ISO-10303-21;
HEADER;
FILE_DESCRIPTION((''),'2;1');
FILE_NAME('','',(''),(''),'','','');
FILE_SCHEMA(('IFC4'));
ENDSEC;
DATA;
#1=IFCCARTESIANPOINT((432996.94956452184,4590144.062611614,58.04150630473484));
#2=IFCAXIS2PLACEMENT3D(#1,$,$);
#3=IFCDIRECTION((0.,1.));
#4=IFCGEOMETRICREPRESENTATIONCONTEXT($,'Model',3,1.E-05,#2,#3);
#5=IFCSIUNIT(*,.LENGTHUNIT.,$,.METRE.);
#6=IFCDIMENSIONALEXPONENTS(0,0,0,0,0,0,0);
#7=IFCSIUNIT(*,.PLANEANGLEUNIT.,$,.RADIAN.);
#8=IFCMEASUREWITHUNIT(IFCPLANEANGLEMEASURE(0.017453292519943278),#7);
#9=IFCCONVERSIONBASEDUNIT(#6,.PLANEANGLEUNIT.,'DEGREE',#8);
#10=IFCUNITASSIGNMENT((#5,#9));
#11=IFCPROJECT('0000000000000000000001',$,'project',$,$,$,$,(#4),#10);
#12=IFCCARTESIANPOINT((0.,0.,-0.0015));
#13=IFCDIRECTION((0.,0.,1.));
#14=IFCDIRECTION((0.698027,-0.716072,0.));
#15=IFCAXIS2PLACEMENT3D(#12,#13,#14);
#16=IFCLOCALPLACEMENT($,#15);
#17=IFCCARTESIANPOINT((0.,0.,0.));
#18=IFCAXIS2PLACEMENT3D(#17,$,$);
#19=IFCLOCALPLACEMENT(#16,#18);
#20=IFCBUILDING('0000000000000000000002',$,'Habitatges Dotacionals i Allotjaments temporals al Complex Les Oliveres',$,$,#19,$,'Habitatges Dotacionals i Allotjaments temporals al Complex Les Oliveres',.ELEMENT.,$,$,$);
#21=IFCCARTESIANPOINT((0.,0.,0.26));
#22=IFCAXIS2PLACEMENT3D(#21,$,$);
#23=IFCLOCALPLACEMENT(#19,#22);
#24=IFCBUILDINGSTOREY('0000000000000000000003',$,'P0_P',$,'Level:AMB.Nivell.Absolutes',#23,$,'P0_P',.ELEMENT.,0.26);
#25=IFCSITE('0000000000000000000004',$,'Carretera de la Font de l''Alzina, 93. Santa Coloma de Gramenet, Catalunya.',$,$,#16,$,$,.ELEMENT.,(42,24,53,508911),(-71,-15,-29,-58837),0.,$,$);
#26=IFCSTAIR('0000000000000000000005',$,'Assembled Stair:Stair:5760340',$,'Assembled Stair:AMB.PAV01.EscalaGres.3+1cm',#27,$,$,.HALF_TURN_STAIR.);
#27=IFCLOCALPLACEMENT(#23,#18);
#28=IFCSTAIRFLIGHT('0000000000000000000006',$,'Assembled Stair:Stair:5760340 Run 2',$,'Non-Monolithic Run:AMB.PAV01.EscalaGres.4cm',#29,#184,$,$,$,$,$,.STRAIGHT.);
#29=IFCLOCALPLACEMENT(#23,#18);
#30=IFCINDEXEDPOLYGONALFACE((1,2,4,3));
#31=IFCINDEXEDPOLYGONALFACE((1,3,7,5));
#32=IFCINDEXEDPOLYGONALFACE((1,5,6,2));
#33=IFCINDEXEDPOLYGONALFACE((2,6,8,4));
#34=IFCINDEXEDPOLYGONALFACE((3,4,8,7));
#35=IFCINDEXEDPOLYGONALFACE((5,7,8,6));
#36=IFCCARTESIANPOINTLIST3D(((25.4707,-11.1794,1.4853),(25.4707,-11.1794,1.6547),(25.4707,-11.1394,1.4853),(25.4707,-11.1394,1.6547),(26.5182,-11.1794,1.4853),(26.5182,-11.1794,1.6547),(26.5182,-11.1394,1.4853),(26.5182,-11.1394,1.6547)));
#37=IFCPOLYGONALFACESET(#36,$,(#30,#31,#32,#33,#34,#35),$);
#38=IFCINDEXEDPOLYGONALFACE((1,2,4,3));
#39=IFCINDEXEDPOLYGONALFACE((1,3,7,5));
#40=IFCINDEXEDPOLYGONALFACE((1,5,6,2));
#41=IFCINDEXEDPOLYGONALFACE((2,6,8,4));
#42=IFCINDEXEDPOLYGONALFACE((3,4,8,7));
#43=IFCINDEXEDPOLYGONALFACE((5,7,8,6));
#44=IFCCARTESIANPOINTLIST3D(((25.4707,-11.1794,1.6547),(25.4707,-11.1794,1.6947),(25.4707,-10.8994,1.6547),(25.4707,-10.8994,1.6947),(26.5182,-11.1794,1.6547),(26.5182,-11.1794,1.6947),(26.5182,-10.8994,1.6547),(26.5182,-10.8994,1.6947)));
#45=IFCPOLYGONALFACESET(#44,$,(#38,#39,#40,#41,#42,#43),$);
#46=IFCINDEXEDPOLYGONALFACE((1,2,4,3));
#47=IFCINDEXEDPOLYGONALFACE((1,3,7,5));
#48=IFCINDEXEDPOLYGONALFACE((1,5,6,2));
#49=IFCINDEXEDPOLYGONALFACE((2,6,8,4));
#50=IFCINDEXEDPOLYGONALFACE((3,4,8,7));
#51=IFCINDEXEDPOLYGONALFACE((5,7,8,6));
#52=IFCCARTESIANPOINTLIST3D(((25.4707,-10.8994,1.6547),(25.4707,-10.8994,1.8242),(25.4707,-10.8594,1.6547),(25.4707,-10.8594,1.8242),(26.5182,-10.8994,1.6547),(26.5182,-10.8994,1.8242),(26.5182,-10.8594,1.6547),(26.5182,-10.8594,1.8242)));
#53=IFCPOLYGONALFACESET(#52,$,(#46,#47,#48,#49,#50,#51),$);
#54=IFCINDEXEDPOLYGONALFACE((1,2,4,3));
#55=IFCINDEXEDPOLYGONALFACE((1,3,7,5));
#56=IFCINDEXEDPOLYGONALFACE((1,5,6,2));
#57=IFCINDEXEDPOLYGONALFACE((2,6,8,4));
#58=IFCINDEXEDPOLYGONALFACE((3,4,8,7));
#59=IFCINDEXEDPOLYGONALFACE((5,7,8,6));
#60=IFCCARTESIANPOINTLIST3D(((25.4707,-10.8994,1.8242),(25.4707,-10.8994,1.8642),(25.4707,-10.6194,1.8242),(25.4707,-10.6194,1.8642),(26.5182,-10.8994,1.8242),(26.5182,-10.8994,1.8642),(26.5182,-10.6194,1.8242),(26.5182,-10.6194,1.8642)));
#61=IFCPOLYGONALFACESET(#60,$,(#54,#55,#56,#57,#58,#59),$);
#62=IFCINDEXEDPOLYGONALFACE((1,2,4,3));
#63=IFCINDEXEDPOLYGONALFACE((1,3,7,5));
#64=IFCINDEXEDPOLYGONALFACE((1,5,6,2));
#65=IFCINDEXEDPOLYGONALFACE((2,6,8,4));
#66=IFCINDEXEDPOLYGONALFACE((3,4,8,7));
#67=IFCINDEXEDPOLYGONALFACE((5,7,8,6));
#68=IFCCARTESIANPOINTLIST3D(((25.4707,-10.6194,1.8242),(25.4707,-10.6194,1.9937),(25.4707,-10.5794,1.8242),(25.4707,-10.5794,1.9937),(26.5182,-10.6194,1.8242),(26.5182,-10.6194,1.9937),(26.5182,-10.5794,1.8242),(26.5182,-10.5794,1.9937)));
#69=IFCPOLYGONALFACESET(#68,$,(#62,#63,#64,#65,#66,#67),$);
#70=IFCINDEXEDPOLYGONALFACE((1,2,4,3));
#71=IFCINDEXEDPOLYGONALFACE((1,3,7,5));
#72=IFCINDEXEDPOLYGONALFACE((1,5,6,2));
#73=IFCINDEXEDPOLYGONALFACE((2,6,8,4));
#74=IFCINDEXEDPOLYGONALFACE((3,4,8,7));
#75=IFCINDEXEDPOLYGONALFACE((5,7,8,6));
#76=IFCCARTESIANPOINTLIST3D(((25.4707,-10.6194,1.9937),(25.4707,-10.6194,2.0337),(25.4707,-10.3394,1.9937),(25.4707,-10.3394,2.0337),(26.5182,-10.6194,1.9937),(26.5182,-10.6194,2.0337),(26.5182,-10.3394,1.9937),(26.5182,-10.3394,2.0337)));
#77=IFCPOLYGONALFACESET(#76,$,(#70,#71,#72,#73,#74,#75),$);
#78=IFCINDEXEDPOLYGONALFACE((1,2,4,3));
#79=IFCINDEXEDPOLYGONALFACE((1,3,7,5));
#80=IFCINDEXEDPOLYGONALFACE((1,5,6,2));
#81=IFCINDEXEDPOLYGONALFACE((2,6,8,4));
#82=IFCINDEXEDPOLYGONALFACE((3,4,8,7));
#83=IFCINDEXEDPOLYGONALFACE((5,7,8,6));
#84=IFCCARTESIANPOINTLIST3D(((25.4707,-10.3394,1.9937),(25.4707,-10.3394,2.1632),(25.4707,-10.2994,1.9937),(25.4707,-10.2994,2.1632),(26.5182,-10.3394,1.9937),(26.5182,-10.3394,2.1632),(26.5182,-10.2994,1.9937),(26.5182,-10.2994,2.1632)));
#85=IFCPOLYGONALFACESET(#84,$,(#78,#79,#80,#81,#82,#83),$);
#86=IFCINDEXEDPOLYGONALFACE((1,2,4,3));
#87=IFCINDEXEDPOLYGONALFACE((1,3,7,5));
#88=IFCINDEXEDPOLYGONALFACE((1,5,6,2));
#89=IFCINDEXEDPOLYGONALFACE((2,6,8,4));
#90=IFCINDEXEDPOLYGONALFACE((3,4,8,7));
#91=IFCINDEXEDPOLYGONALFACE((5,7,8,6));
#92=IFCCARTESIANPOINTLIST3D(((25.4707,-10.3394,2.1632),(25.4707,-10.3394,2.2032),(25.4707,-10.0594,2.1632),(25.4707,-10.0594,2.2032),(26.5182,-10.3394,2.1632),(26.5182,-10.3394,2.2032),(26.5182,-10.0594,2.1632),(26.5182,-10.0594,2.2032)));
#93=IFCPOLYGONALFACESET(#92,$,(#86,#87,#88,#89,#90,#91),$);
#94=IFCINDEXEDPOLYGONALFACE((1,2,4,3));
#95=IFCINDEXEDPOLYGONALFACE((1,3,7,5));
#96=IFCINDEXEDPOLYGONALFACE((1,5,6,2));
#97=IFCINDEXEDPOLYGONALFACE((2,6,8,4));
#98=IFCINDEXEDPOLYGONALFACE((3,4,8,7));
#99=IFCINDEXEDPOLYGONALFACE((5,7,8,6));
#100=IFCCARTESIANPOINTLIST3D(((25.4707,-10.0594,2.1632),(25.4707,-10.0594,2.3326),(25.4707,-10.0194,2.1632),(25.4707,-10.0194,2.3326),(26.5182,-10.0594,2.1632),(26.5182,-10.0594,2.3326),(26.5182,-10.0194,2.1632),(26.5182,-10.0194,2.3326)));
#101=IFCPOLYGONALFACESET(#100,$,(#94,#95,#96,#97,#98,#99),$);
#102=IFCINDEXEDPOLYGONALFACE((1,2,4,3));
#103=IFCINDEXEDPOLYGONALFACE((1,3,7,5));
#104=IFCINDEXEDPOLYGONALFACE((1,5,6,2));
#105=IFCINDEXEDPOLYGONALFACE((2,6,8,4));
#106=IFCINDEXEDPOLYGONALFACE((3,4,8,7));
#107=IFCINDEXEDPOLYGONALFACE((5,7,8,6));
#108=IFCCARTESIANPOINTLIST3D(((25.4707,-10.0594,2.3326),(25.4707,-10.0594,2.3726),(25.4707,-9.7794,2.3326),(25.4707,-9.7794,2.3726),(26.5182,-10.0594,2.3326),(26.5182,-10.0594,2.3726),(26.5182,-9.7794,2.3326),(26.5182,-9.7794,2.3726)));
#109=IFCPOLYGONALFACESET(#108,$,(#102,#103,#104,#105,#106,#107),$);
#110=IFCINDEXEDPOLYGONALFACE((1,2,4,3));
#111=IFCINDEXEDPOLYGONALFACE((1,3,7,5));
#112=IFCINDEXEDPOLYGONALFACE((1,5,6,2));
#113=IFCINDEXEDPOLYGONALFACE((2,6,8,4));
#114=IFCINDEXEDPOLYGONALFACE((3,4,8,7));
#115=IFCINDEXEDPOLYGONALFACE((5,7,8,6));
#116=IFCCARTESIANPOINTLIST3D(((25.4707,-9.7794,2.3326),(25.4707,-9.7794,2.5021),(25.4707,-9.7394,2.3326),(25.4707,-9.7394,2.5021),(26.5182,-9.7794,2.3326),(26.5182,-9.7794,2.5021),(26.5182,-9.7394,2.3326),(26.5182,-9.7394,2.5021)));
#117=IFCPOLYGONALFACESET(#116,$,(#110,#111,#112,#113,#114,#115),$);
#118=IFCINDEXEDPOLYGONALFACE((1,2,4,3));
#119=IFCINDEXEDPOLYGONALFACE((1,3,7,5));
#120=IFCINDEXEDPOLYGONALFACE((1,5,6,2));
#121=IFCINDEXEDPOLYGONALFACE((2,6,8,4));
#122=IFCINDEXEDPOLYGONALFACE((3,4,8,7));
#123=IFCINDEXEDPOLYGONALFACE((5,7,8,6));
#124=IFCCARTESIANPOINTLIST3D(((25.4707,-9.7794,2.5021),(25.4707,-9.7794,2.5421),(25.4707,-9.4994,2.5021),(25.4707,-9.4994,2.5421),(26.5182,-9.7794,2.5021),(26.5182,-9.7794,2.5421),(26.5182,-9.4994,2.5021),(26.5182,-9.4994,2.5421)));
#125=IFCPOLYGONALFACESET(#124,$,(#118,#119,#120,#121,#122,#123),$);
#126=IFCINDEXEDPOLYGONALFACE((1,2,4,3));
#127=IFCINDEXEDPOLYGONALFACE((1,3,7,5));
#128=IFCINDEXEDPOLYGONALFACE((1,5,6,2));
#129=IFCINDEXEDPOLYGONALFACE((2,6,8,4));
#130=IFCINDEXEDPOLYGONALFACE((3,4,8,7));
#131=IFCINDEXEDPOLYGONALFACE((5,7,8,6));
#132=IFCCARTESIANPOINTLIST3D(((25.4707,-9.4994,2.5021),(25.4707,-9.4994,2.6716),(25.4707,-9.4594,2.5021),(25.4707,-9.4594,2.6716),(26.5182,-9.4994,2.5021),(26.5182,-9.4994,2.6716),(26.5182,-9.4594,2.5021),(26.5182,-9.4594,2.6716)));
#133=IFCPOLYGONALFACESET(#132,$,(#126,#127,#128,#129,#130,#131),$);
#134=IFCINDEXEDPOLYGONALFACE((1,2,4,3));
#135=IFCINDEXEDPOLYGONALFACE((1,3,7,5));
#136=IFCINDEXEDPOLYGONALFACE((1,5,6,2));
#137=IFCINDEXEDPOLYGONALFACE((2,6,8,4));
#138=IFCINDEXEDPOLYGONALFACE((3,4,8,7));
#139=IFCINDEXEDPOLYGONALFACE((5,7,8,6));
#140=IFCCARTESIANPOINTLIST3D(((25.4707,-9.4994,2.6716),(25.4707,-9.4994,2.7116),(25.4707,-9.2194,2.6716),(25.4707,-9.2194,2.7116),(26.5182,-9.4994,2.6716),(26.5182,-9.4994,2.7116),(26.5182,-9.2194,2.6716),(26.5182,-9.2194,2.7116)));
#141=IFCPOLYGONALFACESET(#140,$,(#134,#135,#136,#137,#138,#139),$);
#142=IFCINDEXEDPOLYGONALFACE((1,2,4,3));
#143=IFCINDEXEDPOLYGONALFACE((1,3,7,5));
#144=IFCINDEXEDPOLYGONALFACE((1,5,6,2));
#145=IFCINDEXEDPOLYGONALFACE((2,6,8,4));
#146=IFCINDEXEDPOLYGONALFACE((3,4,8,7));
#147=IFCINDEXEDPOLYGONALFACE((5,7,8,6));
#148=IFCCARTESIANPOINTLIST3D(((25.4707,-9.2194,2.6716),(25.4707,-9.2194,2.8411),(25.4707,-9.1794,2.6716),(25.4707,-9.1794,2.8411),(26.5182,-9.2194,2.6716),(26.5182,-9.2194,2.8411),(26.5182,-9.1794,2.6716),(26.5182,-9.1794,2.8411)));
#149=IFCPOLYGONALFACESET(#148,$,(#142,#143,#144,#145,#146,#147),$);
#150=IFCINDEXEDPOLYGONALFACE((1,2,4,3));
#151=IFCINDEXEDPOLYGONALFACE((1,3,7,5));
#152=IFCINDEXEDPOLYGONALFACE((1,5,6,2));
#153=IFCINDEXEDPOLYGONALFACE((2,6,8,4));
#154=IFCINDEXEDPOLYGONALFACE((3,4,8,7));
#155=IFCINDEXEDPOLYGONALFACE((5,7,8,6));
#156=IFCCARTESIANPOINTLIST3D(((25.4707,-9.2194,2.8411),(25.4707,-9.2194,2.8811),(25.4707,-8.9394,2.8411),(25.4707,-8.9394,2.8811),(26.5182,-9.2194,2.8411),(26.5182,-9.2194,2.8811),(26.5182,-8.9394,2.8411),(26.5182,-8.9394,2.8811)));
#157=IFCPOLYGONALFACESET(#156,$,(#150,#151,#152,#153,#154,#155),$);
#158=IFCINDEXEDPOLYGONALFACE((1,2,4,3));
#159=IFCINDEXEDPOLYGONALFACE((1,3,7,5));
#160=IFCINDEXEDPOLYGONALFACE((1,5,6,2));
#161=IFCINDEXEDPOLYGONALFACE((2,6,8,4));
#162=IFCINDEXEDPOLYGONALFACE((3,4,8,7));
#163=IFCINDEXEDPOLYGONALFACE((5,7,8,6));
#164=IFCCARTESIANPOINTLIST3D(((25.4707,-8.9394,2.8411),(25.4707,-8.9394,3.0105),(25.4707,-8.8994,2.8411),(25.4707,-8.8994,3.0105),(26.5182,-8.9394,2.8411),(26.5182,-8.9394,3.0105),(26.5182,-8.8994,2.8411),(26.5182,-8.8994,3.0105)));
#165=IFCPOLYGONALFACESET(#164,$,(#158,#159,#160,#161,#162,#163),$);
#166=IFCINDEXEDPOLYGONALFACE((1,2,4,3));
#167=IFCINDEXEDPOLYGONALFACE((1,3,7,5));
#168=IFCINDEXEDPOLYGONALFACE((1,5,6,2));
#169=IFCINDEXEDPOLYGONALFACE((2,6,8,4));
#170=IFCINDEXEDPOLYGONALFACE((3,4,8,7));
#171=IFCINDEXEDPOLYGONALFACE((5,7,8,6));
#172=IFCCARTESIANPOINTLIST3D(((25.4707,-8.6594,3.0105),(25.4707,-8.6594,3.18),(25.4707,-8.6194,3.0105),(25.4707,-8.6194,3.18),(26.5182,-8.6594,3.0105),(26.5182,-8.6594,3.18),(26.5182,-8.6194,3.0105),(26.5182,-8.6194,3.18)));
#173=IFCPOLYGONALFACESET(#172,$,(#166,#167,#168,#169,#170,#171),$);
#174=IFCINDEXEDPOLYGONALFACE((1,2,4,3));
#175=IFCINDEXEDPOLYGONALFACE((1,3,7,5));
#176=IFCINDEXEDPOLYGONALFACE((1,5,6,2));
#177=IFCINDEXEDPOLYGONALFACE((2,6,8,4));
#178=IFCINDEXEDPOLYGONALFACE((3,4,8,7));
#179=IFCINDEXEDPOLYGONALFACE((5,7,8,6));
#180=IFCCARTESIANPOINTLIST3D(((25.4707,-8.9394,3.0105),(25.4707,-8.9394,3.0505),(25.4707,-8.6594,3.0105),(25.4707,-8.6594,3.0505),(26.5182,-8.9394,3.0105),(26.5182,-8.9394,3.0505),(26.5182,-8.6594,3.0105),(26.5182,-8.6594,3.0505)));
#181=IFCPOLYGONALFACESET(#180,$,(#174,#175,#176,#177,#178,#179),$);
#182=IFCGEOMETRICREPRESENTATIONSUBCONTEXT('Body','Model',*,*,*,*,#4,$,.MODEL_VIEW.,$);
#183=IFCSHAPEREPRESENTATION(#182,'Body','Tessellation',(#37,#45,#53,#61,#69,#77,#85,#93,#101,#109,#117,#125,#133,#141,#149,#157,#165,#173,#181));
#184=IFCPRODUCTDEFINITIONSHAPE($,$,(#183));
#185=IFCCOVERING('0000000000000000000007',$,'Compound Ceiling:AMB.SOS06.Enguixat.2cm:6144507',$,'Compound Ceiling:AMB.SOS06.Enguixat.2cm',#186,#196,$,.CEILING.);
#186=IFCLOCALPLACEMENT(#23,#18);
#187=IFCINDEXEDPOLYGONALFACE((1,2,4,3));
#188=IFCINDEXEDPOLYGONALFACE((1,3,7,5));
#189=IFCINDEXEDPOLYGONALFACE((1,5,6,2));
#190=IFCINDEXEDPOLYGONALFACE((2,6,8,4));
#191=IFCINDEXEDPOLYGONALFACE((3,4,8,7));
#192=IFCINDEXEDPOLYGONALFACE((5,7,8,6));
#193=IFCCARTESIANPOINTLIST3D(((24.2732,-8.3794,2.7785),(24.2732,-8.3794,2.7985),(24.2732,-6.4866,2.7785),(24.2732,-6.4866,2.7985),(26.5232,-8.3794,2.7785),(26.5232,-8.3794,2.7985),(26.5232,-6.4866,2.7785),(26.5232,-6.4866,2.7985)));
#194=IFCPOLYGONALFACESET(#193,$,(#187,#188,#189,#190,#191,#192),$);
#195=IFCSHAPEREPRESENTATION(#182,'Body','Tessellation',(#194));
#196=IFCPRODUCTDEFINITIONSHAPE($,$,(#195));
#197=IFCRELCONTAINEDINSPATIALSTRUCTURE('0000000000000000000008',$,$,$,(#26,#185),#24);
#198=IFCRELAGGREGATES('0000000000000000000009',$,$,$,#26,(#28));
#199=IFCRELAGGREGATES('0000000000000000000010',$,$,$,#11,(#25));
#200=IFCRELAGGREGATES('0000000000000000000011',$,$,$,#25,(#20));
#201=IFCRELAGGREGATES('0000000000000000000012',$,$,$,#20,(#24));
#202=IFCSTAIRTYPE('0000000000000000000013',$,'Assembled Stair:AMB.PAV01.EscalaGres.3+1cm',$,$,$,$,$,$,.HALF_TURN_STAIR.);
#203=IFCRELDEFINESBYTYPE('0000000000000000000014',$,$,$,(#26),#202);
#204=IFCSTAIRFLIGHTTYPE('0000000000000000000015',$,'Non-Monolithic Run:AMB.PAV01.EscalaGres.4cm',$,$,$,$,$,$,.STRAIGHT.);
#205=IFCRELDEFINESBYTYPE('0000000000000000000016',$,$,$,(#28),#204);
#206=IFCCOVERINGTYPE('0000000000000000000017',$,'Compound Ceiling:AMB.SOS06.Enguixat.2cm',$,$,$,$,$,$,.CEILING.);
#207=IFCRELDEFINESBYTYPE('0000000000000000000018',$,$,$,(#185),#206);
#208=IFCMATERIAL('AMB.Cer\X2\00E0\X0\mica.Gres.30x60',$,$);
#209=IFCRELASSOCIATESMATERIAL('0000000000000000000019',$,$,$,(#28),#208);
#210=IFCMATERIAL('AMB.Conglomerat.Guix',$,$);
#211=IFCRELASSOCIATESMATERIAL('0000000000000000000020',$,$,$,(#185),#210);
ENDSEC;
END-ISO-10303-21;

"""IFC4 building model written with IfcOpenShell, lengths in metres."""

from ifc_helpers import new_model, entity, si_unit, converted_unit, direction, frame, origin, place, context, subcontext, project, spatial, indexed_curve, outline, extrude, material, type_object, element, aggregate, save


model = new_model("IFC4")

# Units and contexts
model_context = context("Model", 3, precision=1e-05, world=frame((432996.94956452184, 4590144.062611614, 58.04150630473484)), true_north=direction((0.0, 1.0)))
body_context = subcontext(model_context, "Body", "Model", "MODEL_VIEW")
ifc_project = project(units=[si_unit("LENGTHUNIT", "METRE"), converted_unit("PLANEANGLEUNIT", "DEGREE", entity("IfcPlaneAngleMeasure", 0.017453292519943278), si_unit("PLANEANGLEUNIT", "RADIAN"), dimensions=[0, 0, 0, 0, 0, 0, 0])], contexts=[model_context])

# Site, building, storey
site_placement = place(None, frame((0.0, 0.0, -0.0015), z_axis=(0.0, 0.0, 1.0), x_axis=(0.698027, -0.716072, 0.0)))
site = spatial("IfcSite", under=ifc_project, at=site_placement, Name="Carretera de la Font de l'Alzina, 93. Santa Coloma de Gramenet, Catalunya.", CompositionType="ELEMENT", RefLatitude=(42, 24, 53, 508911), RefLongitude=(-71, -15, -29, -58837), RefElevation=0.0)
building_placement = place(site_placement, origin())
building = spatial("IfcBuilding", under=site, at=building_placement, Name="Habitatges Dotacionals i Allotjaments temporals al Complex Les Oliveres", LongName="Habitatges Dotacionals i Allotjaments temporals al Complex Les Oliveres", CompositionType="ELEMENT")
storey_placement = place(building_placement, frame((0.0, 0.0, 0.26)))
storey = spatial("IfcBuildingStorey", under=building, at=storey_placement, Name="P0_P", ObjectType="Level:AMB.Nivell.Absolutes", LongName="P0_P", CompositionType="ELEMENT", Elevation=0.26)

# Stair
stair_type_1 = type_object("IfcStairType", Name="Assembled Stair:AMB.PAV01.EscalaGres.3+1cm", PredefinedType="HALF_TURN_STAIR")
stair_1_placement = place(storey_placement, origin())
stair_1 = element("IfcStair", 1, at=stair_1_placement, inside=storey, type_object=stair_type_1, Name="Assembled Stair:Stair:5760340", ObjectType="Assembled Stair:AMB.PAV01.EscalaGres.3+1cm", PredefinedType="HALF_TURN_STAIR")
ifc_material_1 = material(Name="AMB.Ceràmica.Gres.30x60")

# Shared definitions
stair_flight_type = type_object("IfcStairFlightType", Name="Non-Monolithic Run:AMB.PAV01.EscalaGres.4cm", PredefinedType="STRAIGHT")

# Stair flight
stair_flight_1_placement = place(stair_1_placement, origin())
stair_flight_1 = element("IfcStairFlight", 2, at=stair_flight_1_placement, type_object=stair_flight_type, material=ifc_material_1, Name="Assembled Stair:Stair:5760340 Run 2", ObjectType="Non-Monolithic Run:AMB.PAV01.EscalaGres.4cm", PredefinedType="STRAIGHT", context=body_context, shape_type="SweptSolid", body=[
    extrude(outline(indexed_curve([(-0.5238, -0.02), (0.5238, -0.02), (0.5238, 0.02), (-0.5238, 0.02), (-0.5238, -0.02)], self_intersect=False)), frame((25.9944, -11.1594, 1.4853), z_axis=(0.0, 0.0, 1.0), x_axis=(-1.0, 0.0, 0.0)), (0.0, 0.0, 1.0), 0.1695),
    extrude(outline(indexed_curve([(-0.14, -0.5238), (0.14, -0.5238), (0.14, 0.5238), (-0.14, 0.5238), (-0.14, -0.5238)], self_intersect=False)), frame((25.9944, -11.0394, 1.6547), z_axis=(0.0, 0.0, 1.0), x_axis=(0.0, -1.0, 0.0)), (0.0, 0.0, 1.0), 0.04),
    extrude(outline(indexed_curve([(-0.5238, -0.02), (0.5238, -0.02), (0.5238, 0.02), (-0.5238, 0.02), (-0.5238, -0.02)], self_intersect=False)), frame((25.9944, -10.8794, 1.6547), z_axis=(0.0, 0.0, 1.0), x_axis=(-1.0, 0.0, 0.0)), (0.0, 0.0, 1.0), 0.1695),
    extrude(outline(indexed_curve([(-0.14, -0.5238), (0.14, -0.5238), (0.14, 0.5238), (-0.14, 0.5238), (-0.14, -0.5238)], self_intersect=False)), frame((25.9944, -10.7594, 1.8242), z_axis=(0.0, 0.0, 1.0), x_axis=(0.0, -1.0, 0.0)), (0.0, 0.0, 1.0), 0.04),
    extrude(outline(indexed_curve([(-0.5238, -0.02), (0.5238, -0.02), (0.5238, 0.02), (-0.5238, 0.02), (-0.5238, -0.02)], self_intersect=False)), frame((25.9944, -10.5994, 1.8242), z_axis=(0.0, 0.0, 1.0), x_axis=(-1.0, 0.0, 0.0)), (0.0, 0.0, 1.0), 0.1695),
    extrude(outline(indexed_curve([(-0.14, -0.5238), (0.14, -0.5238), (0.14, 0.5238), (-0.14, 0.5238), (-0.14, -0.5238)], self_intersect=False)), frame((25.9944, -10.4794, 1.9937), z_axis=(0.0, 0.0, 1.0), x_axis=(0.0, -1.0, 0.0)), (0.0, 0.0, 1.0), 0.04),
    extrude(outline(indexed_curve([(-0.5238, -0.02), (0.5238, -0.02), (0.5238, 0.02), (-0.5238, 0.02), (-0.5238, -0.02)], self_intersect=False)), frame((25.9944, -10.3194, 1.9937), z_axis=(0.0, 0.0, 1.0), x_axis=(-1.0, 0.0, 0.0)), (0.0, 0.0, 1.0), 0.1695),
    extrude(outline(indexed_curve([(-0.14, -0.5238), (0.14, -0.5238), (0.14, 0.5238), (-0.14, 0.5238), (-0.14, -0.5238)], self_intersect=False)), frame((25.9944, -10.1994, 2.1632), z_axis=(0.0, 0.0, 1.0), x_axis=(0.0, -1.0, 0.0)), (0.0, 0.0, 1.0), 0.04),
    extrude(outline(indexed_curve([(-0.5238, -0.02), (0.5238, -0.02), (0.5238, 0.02), (-0.5238, 0.02), (-0.5238, -0.02)], self_intersect=False)), frame((25.9944, -10.0394, 2.1632), z_axis=(0.0, 0.0, 1.0), x_axis=(-1.0, 0.0, 0.0)), (0.0, 0.0, 1.0), 0.1695),
    extrude(outline(indexed_curve([(-0.14, -0.5238), (0.14, -0.5238), (0.14, 0.5238), (-0.14, 0.5238), (-0.14, -0.5238)], self_intersect=False)), frame((25.9944, -9.9194, 2.3326), z_axis=(0.0, 0.0, 1.0), x_axis=(0.0, -1.0, 0.0)), (0.0, 0.0, 1.0), 0.04),
    extrude(outline(indexed_curve([(-0.5238, -0.02), (0.5238, -0.02), (0.5238, 0.02), (-0.5238, 0.02), (-0.5238, -0.02)], self_intersect=False)), frame((25.9944, -9.7594, 2.3326), z_axis=(0.0, 0.0, 1.0), x_axis=(-1.0, 0.0, 0.0)), (0.0, 0.0, 1.0), 0.1695),
    extrude(outline(indexed_curve([(-0.14, -0.5238), (0.14, -0.5238), (0.14, 0.5238), (-0.14, 0.5238), (-0.14, -0.5238)], self_intersect=False)), frame((25.9944, -9.6394, 2.5021), z_axis=(0.0, 0.0, 1.0), x_axis=(0.0, -1.0, 0.0)), (0.0, 0.0, 1.0), 0.04),
    extrude(outline(indexed_curve([(-0.5238, -0.02), (0.5238, -0.02), (0.5238, 0.02), (-0.5238, 0.02), (-0.5238, -0.02)], self_intersect=False)), frame((25.9944, -9.4794, 2.5021), z_axis=(0.0, 0.0, 1.0), x_axis=(-1.0, 0.0, 0.0)), (0.0, 0.0, 1.0), 0.1695),
    extrude(outline(indexed_curve([(-0.14, -0.5238), (0.14, -0.5238), (0.14, 0.5238), (-0.14, 0.5238), (-0.14, -0.5238)], self_intersect=False)), frame((25.9944, -9.3594, 2.6716), z_axis=(0.0, 0.0, 1.0), x_axis=(0.0, -1.0, 0.0)), (0.0, 0.0, 1.0), 0.04),
    extrude(outline(indexed_curve([(-0.5238, -0.02), (0.5238, -0.02), (0.5238, 0.02), (-0.5238, 0.02), (-0.5238, -0.02)], self_intersect=False)), frame((25.9944, -9.1994, 2.6716), z_axis=(0.0, 0.0, 1.0), x_axis=(-1.0, 0.0, 0.0)), (0.0, 0.0, 1.0), 0.1695),
    extrude(outline(indexed_curve([(-0.14, -0.5238), (0.14, -0.5238), (0.14, 0.5238), (-0.14, 0.5238), (-0.14, -0.5238)], self_intersect=False)), frame((25.9944, -9.0794, 2.8411), z_axis=(0.0, 0.0, 1.0), x_axis=(0.0, -1.0, 0.0)), (0.0, 0.0, 1.0), 0.04),
    extrude(outline(indexed_curve([(-0.5238, -0.02), (0.5238, -0.02), (0.5238, 0.02), (-0.5238, 0.02), (-0.5238, -0.02)], self_intersect=False)), frame((25.9944, -8.9194, 2.8411), z_axis=(0.0, 0.0, 1.0), x_axis=(-1.0, 0.0, 0.0)), (0.0, 0.0, 1.0), 0.1695),
    extrude(outline(indexed_curve([(-0.5238, -0.02), (0.5238, -0.02), (0.5238, 0.02), (-0.5238, 0.02), (-0.5238, -0.02)], self_intersect=False)), frame((25.9944, -8.6394, 3.0105), z_axis=(0.0, 0.0, 1.0), x_axis=(-1.0, 0.0, 0.0)), (0.0, 0.0, 1.0), 0.1695),
    extrude(outline(indexed_curve([(-0.14, -0.5238), (0.14, -0.5238), (0.14, 0.5238), (-0.14, 0.5238), (-0.14, -0.5238)], self_intersect=False)), frame((25.9944, -8.7994, 3.0105), z_axis=(0.0, 0.0, 1.0), x_axis=(0.0, -1.0, 0.0)), (0.0, 0.0, 1.0), 0.04),
])
aggregate(stair_1, [stair_flight_1])

# Covering
ifc_material_2 = material(Name="AMB.Conglomerat.Guix")
covering_type_1 = type_object("IfcCoveringType", Name="Compound Ceiling:AMB.SOS06.Enguixat.2cm", PredefinedType="CEILING")
covering_1_placement = place(storey_placement, origin())
element("IfcCovering", 3, at=covering_1_placement, inside=storey, type_object=covering_type_1, material=ifc_material_2, Name="Compound Ceiling:AMB.SOS06.Enguixat.2cm:6144507", ObjectType="Compound Ceiling:AMB.SOS06.Enguixat.2cm", PredefinedType="CEILING", context=body_context, shape_type="SweptSolid", body=[
    extrude(outline(indexed_curve([(-0.9464, -1.125), (0.9464, -1.125), (0.9464, 1.125), (-0.9464, 1.125), (-0.9464, -1.125)], self_intersect=False)), frame((25.3982, -7.433, 2.7785), z_axis=(0.0, 0.0, 1.0), x_axis=(0.0, -1.0, 0.0)), (0.0, 0.0, 1.0), 0.02),
])

save(model, "model.ifc")
